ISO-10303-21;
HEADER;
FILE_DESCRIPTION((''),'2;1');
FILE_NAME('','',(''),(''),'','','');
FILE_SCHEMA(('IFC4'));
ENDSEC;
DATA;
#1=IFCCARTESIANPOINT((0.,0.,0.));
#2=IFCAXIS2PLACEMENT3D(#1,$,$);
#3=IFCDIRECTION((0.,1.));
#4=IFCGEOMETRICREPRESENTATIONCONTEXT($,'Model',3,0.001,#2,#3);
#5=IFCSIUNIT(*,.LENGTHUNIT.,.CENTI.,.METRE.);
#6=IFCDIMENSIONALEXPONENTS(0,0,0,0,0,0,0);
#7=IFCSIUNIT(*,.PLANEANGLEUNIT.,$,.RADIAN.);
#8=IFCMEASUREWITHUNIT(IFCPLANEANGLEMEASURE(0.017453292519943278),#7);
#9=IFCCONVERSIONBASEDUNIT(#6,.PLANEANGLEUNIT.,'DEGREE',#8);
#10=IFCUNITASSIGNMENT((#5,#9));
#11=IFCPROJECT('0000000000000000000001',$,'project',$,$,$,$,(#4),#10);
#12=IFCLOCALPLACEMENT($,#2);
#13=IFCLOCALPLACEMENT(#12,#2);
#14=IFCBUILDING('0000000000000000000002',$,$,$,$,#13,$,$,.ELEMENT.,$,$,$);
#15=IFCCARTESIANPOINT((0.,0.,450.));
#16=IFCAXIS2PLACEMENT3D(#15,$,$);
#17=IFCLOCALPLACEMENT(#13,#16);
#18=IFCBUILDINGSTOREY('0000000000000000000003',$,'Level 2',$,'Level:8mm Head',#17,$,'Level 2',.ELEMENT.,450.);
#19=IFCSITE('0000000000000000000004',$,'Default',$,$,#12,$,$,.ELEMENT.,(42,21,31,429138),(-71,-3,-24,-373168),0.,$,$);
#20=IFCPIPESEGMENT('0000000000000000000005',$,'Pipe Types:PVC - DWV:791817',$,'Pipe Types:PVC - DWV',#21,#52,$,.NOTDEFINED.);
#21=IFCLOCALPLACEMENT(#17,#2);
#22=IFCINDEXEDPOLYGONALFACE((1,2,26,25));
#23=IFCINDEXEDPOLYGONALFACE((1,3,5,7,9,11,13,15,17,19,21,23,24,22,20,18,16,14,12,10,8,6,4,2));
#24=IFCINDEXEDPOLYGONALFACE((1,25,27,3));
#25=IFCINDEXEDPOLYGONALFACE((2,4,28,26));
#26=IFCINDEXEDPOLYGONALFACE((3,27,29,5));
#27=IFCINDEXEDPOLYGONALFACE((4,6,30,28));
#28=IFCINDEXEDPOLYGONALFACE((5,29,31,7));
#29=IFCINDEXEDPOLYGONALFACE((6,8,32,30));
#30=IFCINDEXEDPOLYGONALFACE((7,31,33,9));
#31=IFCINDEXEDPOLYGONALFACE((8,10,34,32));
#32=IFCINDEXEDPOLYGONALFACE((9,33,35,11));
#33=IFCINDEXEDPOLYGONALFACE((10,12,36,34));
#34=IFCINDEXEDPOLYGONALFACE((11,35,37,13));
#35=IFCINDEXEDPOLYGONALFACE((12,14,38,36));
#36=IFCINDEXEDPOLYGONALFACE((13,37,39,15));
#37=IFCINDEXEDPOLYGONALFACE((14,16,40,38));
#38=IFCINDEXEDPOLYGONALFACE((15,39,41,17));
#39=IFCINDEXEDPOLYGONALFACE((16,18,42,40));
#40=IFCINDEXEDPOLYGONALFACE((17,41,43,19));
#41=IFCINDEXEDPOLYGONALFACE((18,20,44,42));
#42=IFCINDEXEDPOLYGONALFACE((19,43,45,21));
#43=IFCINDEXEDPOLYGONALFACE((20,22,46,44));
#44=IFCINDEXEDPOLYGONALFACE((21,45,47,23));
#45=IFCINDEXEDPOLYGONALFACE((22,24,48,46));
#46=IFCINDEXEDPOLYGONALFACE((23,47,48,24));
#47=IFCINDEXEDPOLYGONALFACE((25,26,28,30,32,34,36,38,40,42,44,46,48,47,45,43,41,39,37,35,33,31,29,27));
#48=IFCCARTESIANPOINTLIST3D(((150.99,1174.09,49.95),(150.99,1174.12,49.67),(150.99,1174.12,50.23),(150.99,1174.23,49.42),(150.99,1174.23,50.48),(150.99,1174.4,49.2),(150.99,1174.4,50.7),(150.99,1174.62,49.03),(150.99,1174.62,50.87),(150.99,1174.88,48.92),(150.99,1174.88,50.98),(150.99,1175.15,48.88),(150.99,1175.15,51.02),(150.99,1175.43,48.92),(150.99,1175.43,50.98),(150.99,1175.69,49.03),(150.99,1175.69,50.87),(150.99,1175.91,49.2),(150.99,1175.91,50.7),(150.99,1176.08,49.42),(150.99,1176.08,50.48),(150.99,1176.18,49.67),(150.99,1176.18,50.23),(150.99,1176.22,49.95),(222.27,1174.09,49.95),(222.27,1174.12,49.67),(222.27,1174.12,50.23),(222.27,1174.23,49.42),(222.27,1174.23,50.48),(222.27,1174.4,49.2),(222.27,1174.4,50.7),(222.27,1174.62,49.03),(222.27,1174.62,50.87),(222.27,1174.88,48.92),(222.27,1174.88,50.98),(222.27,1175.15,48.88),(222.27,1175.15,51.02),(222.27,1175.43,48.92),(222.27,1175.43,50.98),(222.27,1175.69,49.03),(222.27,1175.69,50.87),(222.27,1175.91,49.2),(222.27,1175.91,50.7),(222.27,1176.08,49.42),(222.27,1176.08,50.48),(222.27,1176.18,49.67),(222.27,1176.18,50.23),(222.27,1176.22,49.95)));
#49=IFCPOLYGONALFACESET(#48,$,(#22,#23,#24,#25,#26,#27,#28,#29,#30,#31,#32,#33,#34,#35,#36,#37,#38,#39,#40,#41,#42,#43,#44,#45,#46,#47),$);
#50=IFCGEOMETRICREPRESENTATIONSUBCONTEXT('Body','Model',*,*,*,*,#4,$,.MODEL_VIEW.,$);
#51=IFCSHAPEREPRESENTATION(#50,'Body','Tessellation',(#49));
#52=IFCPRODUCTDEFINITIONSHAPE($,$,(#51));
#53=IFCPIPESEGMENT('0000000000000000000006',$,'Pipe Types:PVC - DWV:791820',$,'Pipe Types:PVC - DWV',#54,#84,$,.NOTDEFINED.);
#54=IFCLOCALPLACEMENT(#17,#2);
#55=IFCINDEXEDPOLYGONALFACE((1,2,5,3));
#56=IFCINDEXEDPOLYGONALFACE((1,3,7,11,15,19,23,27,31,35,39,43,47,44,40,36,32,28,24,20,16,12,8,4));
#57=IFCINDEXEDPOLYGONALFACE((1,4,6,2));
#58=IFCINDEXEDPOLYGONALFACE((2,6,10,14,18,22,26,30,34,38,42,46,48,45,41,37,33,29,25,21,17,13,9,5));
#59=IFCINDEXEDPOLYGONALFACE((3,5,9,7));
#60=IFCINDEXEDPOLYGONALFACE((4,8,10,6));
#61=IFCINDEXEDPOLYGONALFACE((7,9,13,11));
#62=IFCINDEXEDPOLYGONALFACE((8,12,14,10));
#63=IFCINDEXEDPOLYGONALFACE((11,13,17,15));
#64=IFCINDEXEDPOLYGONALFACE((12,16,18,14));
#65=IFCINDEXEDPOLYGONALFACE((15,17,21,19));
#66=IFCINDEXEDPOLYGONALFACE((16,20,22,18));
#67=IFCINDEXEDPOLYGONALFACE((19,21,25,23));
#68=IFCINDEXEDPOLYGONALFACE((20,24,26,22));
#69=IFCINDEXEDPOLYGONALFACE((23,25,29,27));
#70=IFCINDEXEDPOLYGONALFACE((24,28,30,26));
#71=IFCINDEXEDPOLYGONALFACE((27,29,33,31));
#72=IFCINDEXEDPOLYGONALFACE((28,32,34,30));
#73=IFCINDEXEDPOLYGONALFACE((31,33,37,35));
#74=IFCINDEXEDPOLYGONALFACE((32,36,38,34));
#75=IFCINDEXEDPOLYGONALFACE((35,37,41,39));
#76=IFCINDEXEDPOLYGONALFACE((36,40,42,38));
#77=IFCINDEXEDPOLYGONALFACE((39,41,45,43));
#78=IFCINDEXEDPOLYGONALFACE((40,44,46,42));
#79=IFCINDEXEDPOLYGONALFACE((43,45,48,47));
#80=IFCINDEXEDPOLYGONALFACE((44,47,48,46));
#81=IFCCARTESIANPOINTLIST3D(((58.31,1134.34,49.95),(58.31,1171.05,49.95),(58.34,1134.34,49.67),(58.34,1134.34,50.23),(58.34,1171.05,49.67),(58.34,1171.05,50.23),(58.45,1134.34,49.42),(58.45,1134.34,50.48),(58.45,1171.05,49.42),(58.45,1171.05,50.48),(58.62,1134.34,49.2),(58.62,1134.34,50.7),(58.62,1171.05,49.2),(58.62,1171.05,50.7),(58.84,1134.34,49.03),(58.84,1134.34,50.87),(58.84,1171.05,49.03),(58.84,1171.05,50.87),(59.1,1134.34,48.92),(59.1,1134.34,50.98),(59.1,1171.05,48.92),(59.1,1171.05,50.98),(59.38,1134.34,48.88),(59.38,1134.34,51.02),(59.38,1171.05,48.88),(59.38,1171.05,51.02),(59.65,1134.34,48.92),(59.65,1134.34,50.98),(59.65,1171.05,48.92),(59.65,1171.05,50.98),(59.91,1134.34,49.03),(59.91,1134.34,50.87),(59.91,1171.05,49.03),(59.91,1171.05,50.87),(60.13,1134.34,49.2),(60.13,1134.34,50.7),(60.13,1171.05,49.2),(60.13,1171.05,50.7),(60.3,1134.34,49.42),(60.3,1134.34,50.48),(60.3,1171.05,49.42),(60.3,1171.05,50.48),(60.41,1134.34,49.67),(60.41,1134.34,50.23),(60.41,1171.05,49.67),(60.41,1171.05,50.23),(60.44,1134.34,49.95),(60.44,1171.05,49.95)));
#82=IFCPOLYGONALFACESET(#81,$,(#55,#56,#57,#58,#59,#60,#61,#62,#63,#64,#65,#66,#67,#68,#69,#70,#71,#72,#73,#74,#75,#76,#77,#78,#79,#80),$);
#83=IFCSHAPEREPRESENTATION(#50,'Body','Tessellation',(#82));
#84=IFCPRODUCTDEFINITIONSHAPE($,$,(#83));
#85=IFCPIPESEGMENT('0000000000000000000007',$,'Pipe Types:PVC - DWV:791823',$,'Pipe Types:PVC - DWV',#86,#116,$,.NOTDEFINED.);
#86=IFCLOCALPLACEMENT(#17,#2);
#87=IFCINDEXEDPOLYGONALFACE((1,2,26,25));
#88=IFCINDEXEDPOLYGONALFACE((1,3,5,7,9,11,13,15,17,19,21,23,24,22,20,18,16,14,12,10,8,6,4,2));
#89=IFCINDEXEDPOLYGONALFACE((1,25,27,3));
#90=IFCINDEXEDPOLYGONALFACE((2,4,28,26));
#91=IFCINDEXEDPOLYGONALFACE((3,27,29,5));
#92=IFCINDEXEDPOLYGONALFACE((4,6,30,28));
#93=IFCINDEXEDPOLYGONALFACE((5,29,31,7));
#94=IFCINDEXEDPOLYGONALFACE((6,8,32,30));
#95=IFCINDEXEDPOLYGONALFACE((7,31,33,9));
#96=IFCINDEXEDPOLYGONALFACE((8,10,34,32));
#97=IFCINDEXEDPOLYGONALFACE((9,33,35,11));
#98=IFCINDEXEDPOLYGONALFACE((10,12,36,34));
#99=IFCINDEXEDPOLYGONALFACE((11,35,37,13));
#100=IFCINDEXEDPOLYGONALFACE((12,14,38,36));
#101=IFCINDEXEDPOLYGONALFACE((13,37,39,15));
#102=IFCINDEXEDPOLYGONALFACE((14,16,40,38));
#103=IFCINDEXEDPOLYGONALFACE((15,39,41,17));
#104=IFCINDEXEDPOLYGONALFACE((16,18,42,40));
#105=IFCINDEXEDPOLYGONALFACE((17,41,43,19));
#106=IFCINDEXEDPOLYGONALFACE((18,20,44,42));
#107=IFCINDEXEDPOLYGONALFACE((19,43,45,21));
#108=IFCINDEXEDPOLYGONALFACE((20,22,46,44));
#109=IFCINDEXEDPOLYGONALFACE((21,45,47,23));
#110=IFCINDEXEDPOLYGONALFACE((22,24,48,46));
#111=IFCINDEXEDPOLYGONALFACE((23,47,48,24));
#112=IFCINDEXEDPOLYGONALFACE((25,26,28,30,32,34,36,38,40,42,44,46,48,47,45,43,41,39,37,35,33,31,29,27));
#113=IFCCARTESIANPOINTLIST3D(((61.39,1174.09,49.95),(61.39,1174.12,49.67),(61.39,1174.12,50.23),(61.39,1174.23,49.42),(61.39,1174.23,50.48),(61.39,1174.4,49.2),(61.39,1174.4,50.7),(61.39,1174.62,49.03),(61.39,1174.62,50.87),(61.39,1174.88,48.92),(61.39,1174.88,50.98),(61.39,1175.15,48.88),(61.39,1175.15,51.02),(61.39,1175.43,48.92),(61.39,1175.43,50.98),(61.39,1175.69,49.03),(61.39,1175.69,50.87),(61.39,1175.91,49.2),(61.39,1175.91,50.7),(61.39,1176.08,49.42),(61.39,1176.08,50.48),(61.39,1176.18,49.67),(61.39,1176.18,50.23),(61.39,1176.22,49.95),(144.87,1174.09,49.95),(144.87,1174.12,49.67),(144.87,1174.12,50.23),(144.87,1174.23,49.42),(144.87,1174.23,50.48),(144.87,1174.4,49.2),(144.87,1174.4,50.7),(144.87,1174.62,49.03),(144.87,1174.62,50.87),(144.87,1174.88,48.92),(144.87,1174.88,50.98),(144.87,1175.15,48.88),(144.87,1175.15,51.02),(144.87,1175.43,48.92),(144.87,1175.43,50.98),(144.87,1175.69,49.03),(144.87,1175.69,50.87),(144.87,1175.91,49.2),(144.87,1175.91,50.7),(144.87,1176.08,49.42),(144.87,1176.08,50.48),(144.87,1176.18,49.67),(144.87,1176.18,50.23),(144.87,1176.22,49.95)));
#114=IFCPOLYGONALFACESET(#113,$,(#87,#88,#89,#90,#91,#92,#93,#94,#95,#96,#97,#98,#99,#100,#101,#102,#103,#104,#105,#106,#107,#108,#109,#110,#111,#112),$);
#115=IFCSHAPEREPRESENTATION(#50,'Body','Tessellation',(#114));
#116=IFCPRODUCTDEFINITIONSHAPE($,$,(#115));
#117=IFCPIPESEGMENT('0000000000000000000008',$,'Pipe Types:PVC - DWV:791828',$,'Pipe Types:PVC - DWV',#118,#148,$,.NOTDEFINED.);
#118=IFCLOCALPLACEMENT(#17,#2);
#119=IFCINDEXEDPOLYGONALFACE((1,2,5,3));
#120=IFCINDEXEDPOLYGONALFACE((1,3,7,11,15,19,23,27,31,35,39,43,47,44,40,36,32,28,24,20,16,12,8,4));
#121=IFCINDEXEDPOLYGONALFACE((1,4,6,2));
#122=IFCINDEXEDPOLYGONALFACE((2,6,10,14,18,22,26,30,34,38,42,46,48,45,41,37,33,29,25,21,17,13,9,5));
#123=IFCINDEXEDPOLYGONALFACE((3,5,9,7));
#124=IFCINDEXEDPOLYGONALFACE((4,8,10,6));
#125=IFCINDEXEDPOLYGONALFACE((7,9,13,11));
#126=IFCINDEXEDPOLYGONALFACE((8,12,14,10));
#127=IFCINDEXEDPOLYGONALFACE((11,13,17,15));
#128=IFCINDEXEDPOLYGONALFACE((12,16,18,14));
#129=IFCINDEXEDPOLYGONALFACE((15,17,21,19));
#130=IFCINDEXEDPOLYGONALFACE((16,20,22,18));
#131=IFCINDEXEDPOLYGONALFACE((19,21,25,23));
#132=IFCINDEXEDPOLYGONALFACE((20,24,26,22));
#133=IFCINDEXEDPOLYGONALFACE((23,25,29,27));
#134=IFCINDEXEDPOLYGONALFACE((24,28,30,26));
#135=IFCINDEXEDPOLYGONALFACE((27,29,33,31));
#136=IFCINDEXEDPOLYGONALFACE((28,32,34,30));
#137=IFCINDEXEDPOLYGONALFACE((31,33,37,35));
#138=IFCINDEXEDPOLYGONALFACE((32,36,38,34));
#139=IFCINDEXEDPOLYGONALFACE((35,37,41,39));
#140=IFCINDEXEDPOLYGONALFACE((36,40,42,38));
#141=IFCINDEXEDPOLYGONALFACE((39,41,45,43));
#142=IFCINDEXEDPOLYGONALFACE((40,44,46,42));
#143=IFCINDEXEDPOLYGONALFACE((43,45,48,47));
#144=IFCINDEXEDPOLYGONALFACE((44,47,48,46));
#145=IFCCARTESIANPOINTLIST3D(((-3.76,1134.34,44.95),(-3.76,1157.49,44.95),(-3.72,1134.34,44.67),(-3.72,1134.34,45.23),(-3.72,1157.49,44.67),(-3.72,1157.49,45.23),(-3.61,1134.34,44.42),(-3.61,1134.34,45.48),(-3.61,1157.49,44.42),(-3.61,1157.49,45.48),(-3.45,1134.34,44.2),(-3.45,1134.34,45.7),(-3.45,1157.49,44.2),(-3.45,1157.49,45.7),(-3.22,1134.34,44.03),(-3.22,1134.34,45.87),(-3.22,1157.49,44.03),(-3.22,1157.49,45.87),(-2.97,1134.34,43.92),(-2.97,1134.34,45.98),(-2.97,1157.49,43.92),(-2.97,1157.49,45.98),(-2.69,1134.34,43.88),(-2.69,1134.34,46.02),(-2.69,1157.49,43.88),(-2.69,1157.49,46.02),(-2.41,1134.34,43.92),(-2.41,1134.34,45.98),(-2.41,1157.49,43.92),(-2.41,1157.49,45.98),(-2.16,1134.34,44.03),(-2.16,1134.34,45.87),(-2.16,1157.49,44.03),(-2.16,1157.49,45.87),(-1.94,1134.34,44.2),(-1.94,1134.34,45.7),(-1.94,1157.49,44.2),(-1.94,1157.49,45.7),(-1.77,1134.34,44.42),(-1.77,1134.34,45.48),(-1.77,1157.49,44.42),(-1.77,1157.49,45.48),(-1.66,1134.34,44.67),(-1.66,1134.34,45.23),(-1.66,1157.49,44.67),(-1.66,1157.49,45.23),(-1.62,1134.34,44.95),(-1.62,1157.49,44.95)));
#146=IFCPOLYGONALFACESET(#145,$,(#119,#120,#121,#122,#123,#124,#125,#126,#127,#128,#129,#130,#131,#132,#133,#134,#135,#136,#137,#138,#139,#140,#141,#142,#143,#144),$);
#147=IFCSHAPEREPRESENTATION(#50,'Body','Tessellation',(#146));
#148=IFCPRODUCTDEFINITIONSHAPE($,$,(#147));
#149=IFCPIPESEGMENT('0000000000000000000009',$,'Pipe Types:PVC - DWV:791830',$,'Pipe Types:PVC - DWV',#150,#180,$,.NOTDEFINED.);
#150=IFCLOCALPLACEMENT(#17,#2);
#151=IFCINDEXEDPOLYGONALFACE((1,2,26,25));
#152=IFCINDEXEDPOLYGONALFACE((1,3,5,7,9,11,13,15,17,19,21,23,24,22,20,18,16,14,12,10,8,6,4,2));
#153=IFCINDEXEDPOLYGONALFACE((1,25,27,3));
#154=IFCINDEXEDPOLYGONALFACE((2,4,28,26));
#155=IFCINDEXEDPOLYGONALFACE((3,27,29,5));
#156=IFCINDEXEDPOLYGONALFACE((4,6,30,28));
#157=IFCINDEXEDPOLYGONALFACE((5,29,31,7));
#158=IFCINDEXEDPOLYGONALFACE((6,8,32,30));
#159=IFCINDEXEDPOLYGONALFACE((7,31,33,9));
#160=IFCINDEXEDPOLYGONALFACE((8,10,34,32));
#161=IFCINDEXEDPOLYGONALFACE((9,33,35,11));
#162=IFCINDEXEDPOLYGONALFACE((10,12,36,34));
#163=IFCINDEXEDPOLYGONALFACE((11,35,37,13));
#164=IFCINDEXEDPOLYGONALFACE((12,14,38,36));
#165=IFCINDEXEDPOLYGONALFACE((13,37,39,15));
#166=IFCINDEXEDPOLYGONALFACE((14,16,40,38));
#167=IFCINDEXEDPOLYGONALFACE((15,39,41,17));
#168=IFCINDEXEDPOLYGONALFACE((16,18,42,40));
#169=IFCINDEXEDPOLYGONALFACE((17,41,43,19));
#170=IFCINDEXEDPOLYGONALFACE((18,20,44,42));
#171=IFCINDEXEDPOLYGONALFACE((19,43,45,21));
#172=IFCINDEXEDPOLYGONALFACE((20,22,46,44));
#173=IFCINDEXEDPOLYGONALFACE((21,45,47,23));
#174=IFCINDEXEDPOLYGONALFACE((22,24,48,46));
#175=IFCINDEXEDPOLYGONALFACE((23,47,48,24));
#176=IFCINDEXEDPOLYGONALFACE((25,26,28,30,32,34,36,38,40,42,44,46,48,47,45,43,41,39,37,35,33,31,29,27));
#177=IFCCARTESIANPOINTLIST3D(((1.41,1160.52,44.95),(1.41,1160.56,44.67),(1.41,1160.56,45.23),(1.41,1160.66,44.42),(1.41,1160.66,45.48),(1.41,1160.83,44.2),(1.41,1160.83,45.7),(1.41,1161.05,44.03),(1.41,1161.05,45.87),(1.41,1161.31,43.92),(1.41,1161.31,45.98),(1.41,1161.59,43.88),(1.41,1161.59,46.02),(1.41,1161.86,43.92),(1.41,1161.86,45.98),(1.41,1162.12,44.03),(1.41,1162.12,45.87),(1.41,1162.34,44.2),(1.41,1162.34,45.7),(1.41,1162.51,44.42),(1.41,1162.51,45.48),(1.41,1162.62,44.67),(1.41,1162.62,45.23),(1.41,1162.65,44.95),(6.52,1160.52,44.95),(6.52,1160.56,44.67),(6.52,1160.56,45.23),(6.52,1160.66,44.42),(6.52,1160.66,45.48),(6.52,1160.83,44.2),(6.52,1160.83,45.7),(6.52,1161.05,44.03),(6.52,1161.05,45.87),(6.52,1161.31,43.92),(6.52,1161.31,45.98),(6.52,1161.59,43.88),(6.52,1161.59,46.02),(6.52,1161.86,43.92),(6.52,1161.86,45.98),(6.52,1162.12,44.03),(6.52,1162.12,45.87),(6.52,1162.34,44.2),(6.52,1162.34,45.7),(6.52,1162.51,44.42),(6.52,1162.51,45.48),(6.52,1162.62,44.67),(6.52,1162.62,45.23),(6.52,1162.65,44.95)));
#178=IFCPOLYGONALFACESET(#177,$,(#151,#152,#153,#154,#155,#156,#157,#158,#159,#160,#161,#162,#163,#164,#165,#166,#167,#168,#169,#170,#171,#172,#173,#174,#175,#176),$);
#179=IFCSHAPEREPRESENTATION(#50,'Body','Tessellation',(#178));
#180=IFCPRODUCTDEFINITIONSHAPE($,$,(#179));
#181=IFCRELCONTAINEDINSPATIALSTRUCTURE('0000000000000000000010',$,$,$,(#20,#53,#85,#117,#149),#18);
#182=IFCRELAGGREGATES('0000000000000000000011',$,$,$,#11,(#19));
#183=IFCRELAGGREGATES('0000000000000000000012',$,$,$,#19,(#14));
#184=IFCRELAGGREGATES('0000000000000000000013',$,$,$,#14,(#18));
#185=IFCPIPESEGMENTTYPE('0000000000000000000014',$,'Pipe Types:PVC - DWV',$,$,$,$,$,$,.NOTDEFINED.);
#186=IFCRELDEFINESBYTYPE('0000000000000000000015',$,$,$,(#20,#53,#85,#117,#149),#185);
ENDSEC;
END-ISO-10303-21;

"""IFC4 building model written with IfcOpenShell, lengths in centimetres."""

from ifc_helpers import new_model, entity, si_unit, converted_unit, direction, frame, origin, place, context, subcontext, project, spatial, arc, indexed_curve, outline, extrude, type_object, element, save


model = new_model("IFC4")

# Units and contexts
model_context = context("Model", 3, precision=0.001, world=origin(), true_north=direction((0.0, 1.0)))
body_context = subcontext(model_context, "Body", "Model", "MODEL_VIEW")
ifc_project = project(units=[si_unit("LENGTHUNIT", "METRE", prefix="CENTI"), converted_unit("PLANEANGLEUNIT", "DEGREE", entity("IfcPlaneAngleMeasure", 0.017453292519943278), si_unit("PLANEANGLEUNIT", "RADIAN"), dimensions=[0, 0, 0, 0, 0, 0, 0])], contexts=[model_context])

# Site, building, storey
site_placement = place(None, origin())
site = spatial("IfcSite", under=ifc_project, at=site_placement, Name="Default", CompositionType="ELEMENT", RefLatitude=(42, 21, 31, 429138), RefLongitude=(-71, -3, -24, -373168), RefElevation=0.0)
building_placement = place(site_placement, origin())
building = spatial("IfcBuilding", under=site, at=building_placement, CompositionType="ELEMENT")
storey_placement = place(building_placement, frame((0.0, 0.0, 450.0)))
storey = spatial("IfcBuildingStorey", under=building, at=storey_placement, Name="Level 2", ObjectType="Level:8mm Head", LongName="Level 2", CompositionType="ELEMENT", Elevation=450.0)

# Pipe segments
pipe_segment_type = type_object("IfcPipeSegmentType", Name="Pipe Types:PVC - DWV", PredefinedType="NOTDEFINED")
pipe_segment_1_placement = place(storey_placement, origin())
element("IfcPipeSegment", 1, at=pipe_segment_1_placement, inside=storey, type_object=pipe_segment_type, Name="Pipe Types:PVC - DWV:791817", ObjectType="Pipe Types:PVC - DWV", PredefinedType="NOTDEFINED", context=body_context, shape_type="SweptSolid", body=[
    extrude(outline(indexed_curve([(1.07, 0.0), (0.75, 0.75), (0.0, 1.07), (-0.75, 0.75), (-1.07, 0.0), (-0.75, -0.75), (0.0, -1.07), (0.75, -0.75)], segments=[arc(1, 2, 3), arc(3, 4, 5), arc(5, 6, 7), arc(7, 8, 1)], self_intersect=False)), frame((150.99, 1175.15, 49.95), z_axis=(1.0, 0.0, 0.0), x_axis=(0.0, 1.0, 0.0)), (0.0, 0.0, 1.0), 71.29),
])
pipe_segment_2_placement = place(storey_placement, origin())
element("IfcPipeSegment", 2, at=pipe_segment_2_placement, inside=storey, type_object=pipe_segment_type, Name="Pipe Types:PVC - DWV:791820", ObjectType="Pipe Types:PVC - DWV", PredefinedType="NOTDEFINED", context=body_context, shape_type="SweptSolid", body=[
    extrude(outline(indexed_curve([(1.07, 0.0), (0.75, 0.75), (0.0, 1.07), (-0.75, 0.75), (-1.07, 0.0), (-0.75, -0.75), (0.0, -1.07), (0.75, -0.75)], segments=[arc(1, 2, 3), arc(3, 4, 5), arc(5, 6, 7), arc(7, 8, 1)], self_intersect=False)), frame((59.38, 1134.34, 49.95), z_axis=(0.0, 1.0, 0.0), x_axis=(-1.0, 0.0, 0.0)), (0.0, 0.0, 1.0), 36.71),
])
pipe_segment_3_placement = place(storey_placement, origin())
element("IfcPipeSegment", 3, at=pipe_segment_3_placement, inside=storey, type_object=pipe_segment_type, Name="Pipe Types:PVC - DWV:791823", ObjectType="Pipe Types:PVC - DWV", PredefinedType="NOTDEFINED", context=body_context, shape_type="SweptSolid", body=[
    extrude(outline(indexed_curve([(1.07, 0.0), (0.75, 0.75), (0.0, 1.07), (-0.75, 0.75), (-1.07, 0.0), (-0.75, -0.75), (0.0, -1.07), (0.75, -0.75)], segments=[arc(1, 2, 3), arc(3, 4, 5), arc(5, 6, 7), arc(7, 8, 1)], self_intersect=False)), frame((61.39, 1175.15, 49.95), z_axis=(1.0, 0.0, 0.0), x_axis=(0.0, 1.0, 0.0)), (0.0, 0.0, 1.0), 83.49),
])
pipe_segment_4_placement = place(storey_placement, origin())
element("IfcPipeSegment", 4, at=pipe_segment_4_placement, inside=storey, type_object=pipe_segment_type, Name="Pipe Types:PVC - DWV:791828", ObjectType="Pipe Types:PVC - DWV", PredefinedType="NOTDEFINED", context=body_context, shape_type="SweptSolid", body=[
    extrude(outline(indexed_curve([(1.07, 0.0), (0.75, 0.75), (0.0, 1.07), (-0.75, 0.75), (-1.07, 0.0), (-0.75, -0.75), (0.0, -1.07), (0.75, -0.75)], segments=[arc(1, 2, 3), arc(3, 4, 5), arc(5, 6, 7), arc(7, 8, 1)], self_intersect=False)), frame((-2.69, 1134.34, 44.95), z_axis=(0.0, 1.0, 0.0), x_axis=(1.0, 0.0, 0.0)), (0.0, 0.0, 1.0), 23.14),
])
pipe_segment_5_placement = place(storey_placement, origin())
element("IfcPipeSegment", 5, at=pipe_segment_5_placement, inside=storey, type_object=pipe_segment_type, Name="Pipe Types:PVC - DWV:791830", ObjectType="Pipe Types:PVC - DWV", PredefinedType="NOTDEFINED", context=body_context, shape_type="SweptSolid", body=[
    extrude(outline(indexed_curve([(1.07, 0.0), (0.75, 0.75), (0.0, 1.07), (-0.75, 0.75), (-1.07, 0.0), (-0.75, -0.75), (0.0, -1.07), (0.75, -0.75)], segments=[arc(1, 2, 3), arc(3, 4, 5), arc(5, 6, 7), arc(7, 8, 1)], self_intersect=False)), frame((1.41, 1161.59, 44.95), z_axis=(1.0, 0.0, 0.0), x_axis=(0.0, -1.0, 0.0)), (0.0, 0.0, 1.0), 5.11),
])

save(model, "model.ifc")
